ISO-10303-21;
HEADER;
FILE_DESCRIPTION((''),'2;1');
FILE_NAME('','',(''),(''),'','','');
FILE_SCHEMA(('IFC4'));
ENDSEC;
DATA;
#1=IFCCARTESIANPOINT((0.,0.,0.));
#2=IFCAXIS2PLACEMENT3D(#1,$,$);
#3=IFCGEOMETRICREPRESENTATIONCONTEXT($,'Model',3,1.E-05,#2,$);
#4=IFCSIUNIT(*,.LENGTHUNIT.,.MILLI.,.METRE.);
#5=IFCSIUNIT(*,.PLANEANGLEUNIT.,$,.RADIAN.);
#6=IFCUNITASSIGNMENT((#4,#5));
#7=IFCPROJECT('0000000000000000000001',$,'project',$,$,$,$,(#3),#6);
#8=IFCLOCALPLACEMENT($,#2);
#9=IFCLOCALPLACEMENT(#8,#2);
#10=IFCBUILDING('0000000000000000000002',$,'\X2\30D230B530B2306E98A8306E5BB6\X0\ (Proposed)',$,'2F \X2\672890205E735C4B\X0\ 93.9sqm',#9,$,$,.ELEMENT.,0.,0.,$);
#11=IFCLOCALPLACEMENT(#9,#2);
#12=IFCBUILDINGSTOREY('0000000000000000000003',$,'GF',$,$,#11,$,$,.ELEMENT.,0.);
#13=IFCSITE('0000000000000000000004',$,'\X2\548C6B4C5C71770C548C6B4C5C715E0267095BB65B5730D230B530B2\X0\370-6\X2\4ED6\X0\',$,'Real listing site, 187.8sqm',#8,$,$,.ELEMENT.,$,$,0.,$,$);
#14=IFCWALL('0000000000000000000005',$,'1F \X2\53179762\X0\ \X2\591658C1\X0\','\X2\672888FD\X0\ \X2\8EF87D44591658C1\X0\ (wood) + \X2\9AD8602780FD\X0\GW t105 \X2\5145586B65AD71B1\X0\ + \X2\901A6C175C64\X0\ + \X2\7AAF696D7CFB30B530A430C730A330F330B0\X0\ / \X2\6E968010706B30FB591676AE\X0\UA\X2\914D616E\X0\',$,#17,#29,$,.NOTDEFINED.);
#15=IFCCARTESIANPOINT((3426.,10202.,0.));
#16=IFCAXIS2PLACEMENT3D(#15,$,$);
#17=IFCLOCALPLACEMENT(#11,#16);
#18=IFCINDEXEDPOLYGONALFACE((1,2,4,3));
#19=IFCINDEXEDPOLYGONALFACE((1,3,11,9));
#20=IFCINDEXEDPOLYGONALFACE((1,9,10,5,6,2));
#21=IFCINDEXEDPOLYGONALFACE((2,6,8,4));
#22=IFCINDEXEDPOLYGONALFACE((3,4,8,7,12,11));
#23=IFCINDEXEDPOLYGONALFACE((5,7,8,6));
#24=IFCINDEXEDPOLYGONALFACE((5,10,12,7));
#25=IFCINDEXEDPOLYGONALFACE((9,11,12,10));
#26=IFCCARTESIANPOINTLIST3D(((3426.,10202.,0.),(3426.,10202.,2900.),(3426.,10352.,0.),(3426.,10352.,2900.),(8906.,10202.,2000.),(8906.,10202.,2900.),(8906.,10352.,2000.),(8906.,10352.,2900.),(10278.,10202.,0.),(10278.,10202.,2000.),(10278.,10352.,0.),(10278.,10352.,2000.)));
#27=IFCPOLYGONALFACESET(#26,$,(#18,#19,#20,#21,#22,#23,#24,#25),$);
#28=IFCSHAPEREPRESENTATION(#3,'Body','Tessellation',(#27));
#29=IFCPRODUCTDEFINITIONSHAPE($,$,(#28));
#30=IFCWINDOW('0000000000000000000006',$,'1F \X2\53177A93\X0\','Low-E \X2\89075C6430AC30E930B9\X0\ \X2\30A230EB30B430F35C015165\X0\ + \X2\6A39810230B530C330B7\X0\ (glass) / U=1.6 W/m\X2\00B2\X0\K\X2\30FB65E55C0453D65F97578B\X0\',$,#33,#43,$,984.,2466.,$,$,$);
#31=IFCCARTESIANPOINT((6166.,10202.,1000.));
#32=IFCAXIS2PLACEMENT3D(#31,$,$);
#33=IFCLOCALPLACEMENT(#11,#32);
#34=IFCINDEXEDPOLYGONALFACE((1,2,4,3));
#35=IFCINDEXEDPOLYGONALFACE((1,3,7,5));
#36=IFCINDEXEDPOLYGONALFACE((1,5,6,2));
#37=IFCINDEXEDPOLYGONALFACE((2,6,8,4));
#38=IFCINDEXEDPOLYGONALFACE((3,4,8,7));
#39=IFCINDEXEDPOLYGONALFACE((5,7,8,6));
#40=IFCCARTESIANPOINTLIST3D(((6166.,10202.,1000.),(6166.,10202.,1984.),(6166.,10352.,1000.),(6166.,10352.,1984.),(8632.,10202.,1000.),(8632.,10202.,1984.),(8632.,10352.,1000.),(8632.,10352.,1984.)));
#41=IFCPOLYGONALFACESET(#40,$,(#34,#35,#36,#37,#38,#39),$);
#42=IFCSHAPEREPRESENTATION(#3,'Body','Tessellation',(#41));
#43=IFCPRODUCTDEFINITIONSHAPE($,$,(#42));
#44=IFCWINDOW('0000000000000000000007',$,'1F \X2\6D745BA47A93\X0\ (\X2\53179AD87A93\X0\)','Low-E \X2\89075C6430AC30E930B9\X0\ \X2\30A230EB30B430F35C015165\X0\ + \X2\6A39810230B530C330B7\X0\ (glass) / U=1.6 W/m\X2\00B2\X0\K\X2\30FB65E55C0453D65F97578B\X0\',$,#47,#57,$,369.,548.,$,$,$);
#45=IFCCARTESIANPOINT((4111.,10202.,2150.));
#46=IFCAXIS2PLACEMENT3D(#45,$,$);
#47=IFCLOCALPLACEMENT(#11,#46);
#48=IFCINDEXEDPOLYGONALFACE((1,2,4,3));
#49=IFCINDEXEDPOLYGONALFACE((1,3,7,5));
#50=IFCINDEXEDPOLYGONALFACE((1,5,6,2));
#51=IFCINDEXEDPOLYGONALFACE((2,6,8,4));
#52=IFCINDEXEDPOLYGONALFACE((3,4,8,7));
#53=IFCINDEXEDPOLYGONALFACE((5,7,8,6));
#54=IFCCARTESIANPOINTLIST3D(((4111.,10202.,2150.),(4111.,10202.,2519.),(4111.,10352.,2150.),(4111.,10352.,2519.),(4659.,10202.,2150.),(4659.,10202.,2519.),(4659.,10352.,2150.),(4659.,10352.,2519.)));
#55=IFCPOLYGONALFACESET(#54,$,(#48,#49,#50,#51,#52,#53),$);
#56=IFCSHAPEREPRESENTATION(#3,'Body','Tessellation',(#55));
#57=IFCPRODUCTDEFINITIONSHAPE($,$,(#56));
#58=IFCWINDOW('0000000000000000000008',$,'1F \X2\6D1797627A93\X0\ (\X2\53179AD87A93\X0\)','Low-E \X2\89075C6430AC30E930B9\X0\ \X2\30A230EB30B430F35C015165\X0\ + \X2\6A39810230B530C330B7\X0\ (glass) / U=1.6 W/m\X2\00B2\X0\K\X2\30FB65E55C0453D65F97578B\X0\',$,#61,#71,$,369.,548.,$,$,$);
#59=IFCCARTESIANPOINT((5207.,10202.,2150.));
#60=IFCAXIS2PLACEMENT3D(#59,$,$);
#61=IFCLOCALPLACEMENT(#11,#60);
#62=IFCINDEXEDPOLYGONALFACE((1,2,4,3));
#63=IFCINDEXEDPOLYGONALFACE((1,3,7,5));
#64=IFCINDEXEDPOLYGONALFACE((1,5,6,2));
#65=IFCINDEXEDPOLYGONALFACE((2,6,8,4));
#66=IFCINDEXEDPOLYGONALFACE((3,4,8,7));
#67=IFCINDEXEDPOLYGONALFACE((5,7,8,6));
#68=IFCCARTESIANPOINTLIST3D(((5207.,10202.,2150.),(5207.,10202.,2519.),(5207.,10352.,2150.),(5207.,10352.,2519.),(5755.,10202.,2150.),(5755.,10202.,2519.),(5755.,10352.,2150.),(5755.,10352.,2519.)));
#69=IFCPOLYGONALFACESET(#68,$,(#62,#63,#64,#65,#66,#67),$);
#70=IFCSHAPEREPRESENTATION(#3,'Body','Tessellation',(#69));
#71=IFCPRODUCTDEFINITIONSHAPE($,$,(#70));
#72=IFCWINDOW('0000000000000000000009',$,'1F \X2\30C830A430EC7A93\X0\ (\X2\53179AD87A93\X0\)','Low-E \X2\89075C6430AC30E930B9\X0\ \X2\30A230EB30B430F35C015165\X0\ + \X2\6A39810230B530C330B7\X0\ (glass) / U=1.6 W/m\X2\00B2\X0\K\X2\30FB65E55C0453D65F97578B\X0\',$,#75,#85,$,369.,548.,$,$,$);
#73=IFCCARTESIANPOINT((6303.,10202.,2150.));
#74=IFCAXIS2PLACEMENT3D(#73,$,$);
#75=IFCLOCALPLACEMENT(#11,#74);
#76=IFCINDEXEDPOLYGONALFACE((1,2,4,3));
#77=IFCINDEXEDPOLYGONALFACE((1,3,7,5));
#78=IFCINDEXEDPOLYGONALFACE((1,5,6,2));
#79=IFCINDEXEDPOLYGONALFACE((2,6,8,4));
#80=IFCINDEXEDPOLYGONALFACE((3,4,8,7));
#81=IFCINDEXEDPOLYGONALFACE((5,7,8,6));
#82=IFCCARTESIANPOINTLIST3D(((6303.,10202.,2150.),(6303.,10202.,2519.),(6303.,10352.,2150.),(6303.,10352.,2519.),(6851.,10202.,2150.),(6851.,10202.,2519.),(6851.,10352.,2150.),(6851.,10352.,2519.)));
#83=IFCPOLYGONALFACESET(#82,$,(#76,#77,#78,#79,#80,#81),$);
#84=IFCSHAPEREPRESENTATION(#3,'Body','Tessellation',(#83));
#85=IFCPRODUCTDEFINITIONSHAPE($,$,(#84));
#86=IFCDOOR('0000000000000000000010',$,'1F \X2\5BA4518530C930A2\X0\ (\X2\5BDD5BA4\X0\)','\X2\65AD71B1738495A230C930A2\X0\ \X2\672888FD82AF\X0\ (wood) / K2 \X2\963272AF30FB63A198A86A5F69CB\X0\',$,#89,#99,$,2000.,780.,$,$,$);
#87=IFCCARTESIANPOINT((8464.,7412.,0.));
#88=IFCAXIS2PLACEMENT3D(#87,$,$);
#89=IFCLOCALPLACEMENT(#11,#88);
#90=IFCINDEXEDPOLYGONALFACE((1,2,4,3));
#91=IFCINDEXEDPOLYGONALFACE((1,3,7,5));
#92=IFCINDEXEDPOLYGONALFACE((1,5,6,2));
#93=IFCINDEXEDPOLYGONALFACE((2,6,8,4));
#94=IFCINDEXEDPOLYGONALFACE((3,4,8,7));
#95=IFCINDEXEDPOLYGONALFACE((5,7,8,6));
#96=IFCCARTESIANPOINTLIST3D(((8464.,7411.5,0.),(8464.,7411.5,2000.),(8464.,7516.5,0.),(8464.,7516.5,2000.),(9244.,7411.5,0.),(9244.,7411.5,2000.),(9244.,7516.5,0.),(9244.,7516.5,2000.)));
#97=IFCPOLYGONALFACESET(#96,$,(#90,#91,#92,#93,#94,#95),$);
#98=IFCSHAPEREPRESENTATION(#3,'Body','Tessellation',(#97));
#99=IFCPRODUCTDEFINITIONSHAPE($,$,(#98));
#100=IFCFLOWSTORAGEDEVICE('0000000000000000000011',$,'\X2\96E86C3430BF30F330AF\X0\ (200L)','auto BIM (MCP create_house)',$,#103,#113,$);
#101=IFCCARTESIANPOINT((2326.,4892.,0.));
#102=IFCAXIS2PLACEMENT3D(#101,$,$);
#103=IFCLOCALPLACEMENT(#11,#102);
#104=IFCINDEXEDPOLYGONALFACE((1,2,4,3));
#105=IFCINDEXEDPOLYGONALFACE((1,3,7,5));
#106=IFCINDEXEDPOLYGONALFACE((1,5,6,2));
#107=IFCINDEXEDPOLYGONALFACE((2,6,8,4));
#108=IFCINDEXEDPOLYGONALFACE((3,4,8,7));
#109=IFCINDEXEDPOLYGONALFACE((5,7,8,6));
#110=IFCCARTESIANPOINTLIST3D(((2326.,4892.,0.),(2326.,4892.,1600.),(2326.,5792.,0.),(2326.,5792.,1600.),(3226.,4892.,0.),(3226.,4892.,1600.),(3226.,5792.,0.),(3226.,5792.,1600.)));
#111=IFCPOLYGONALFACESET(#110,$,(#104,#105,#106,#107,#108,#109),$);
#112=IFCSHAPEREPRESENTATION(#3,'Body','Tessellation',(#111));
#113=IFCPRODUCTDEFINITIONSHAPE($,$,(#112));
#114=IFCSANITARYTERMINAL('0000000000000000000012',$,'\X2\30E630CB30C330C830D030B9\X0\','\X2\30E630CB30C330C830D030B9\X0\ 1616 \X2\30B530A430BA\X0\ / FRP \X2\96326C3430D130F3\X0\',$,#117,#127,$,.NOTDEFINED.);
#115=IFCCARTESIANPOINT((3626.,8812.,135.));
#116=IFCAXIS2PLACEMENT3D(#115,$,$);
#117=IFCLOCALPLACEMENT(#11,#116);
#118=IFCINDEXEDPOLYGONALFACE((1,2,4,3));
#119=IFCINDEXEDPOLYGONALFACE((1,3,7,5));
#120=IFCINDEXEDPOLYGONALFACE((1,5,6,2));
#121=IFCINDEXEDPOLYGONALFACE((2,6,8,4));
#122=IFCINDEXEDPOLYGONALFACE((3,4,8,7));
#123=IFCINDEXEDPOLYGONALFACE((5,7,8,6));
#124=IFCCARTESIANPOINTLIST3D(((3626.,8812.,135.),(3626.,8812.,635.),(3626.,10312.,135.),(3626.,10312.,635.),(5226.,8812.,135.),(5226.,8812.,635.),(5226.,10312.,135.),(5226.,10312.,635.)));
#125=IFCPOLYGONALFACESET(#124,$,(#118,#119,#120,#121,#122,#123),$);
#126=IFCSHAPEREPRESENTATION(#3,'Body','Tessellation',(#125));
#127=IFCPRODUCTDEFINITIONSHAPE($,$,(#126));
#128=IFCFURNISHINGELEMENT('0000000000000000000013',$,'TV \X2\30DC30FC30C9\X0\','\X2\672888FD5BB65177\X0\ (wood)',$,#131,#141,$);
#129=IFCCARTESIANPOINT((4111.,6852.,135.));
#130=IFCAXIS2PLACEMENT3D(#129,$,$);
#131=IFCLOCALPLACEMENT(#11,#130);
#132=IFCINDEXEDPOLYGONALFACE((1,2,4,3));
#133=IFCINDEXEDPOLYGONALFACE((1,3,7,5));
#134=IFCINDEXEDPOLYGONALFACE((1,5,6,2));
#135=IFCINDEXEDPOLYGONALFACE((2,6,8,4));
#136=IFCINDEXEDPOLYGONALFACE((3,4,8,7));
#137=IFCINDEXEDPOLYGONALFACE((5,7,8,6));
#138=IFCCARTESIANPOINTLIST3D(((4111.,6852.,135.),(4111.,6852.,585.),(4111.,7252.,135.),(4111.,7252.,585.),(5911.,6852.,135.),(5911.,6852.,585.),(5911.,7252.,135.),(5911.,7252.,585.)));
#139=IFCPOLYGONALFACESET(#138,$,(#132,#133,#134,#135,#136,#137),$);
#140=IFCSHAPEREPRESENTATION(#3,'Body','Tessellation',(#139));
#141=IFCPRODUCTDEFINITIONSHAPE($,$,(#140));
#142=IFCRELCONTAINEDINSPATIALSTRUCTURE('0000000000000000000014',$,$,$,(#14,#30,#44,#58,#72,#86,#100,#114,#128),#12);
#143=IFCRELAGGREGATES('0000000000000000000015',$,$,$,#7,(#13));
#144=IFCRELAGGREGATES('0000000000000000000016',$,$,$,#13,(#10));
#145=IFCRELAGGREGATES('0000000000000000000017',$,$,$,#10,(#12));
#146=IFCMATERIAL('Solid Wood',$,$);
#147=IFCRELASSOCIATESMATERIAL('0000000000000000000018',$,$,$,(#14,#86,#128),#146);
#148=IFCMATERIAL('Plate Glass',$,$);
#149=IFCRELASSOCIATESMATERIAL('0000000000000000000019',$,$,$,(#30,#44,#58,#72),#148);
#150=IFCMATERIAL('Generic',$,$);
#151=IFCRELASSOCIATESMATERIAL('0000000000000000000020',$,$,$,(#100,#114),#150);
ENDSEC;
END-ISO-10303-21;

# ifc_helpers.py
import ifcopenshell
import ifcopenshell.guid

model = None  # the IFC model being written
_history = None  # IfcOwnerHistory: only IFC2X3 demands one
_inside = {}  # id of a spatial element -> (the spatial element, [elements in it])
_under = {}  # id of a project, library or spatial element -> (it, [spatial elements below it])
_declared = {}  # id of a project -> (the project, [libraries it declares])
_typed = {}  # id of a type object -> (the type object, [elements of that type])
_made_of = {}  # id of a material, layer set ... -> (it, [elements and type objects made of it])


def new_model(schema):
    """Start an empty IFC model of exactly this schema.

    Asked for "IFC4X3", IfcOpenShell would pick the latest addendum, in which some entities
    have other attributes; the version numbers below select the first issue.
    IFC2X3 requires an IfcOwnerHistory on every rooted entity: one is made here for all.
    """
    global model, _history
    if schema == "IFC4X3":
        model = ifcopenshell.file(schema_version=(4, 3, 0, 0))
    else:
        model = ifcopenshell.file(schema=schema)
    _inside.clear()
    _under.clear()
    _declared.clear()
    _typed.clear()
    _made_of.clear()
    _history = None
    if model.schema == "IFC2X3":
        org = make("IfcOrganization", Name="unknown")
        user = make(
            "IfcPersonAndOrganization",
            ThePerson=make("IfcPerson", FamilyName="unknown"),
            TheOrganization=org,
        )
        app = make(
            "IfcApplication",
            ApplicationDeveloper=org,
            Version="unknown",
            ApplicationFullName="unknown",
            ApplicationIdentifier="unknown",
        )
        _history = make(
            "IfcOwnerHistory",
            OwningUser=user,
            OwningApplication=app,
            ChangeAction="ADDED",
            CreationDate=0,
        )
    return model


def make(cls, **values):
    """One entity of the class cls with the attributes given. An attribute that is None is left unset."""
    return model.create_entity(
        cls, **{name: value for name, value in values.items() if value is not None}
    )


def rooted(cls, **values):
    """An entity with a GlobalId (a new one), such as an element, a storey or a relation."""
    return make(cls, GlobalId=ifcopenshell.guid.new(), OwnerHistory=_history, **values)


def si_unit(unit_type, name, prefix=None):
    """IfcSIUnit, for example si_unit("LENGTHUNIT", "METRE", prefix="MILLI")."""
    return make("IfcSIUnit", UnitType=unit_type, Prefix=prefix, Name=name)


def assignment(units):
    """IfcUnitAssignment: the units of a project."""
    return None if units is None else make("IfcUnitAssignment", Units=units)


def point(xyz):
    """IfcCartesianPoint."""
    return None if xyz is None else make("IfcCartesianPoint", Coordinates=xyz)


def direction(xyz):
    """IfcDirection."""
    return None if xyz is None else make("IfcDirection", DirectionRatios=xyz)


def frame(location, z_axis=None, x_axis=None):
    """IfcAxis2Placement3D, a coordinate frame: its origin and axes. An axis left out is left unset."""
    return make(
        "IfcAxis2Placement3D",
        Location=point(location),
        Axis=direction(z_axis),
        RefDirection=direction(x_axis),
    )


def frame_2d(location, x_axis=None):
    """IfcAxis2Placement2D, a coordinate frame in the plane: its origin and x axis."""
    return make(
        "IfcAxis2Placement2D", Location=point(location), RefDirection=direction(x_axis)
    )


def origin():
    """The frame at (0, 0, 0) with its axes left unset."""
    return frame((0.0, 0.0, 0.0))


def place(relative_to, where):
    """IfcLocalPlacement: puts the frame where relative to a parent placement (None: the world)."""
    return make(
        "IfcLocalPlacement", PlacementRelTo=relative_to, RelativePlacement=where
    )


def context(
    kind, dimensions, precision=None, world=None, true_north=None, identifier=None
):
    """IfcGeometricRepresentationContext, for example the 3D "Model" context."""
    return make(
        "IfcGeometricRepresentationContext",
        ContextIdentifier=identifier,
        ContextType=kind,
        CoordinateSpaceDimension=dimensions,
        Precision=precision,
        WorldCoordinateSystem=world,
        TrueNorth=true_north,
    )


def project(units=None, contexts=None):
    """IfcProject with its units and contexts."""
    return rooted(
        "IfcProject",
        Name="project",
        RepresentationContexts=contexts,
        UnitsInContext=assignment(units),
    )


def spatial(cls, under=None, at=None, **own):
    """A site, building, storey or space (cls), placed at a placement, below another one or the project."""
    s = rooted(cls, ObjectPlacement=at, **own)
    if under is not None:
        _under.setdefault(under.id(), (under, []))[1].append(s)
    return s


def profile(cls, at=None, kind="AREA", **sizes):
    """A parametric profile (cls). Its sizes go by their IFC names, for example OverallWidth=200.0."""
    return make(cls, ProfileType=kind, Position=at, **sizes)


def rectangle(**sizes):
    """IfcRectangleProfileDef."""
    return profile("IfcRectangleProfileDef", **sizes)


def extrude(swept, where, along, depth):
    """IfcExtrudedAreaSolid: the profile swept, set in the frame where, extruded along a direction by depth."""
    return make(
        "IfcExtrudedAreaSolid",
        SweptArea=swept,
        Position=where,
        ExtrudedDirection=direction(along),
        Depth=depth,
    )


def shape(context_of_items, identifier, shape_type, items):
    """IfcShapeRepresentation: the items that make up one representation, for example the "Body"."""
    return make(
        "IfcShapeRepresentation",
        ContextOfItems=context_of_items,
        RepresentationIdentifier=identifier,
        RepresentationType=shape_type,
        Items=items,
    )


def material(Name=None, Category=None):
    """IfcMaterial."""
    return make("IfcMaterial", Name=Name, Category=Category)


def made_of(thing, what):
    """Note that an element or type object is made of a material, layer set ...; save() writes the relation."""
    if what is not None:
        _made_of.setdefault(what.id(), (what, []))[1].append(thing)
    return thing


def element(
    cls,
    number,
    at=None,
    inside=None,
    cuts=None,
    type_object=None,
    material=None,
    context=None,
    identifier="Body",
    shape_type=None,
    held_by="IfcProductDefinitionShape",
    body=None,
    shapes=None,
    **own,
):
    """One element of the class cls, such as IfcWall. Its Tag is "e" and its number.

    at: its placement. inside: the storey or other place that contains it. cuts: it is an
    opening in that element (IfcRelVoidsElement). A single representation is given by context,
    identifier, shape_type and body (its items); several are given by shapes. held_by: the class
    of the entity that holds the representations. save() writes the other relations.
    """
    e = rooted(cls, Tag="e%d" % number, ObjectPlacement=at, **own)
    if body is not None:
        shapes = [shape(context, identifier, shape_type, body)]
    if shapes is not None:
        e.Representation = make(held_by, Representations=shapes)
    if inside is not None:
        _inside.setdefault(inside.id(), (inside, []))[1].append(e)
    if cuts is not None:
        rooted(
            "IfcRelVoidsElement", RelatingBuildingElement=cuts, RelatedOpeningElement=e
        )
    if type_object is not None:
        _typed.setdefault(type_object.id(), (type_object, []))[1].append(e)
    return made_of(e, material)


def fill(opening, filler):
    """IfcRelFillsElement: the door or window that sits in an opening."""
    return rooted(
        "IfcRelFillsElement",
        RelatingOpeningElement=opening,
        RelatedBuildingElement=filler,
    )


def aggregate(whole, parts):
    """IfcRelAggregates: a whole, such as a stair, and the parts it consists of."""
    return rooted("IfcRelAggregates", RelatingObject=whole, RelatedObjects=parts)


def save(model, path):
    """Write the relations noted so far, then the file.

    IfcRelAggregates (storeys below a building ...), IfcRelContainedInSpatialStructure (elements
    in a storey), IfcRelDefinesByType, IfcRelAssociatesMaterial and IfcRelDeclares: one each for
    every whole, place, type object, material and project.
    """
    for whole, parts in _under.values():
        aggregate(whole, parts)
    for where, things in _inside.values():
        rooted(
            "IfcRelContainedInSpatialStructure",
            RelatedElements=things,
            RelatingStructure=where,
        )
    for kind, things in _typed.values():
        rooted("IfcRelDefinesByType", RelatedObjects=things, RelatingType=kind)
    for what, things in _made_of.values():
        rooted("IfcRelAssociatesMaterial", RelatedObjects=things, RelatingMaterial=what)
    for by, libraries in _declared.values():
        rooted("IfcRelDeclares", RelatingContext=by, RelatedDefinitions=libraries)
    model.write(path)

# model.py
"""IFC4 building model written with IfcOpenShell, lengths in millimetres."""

from ifc_helpers import new_model, si_unit, frame, frame_2d, origin, place, context, project, spatial, rectangle, extrude, material, element, fill, save


model = new_model("IFC4")

# Units and contexts
model_context = context("Model", 3, precision=1e-05, world=origin())
ifc_project = project(units=[si_unit("LENGTHUNIT", "METRE", prefix="MILLI"), si_unit("PLANEANGLEUNIT", "RADIAN")], contexts=[model_context])

# Site, building, storey
site_placement = place(None, origin())
site = spatial("IfcSite", under=ifc_project, at=site_placement, Name="和歌山県和歌山市有家字ヒサゲ370-6他", ObjectType="Real listing site, 187.8sqm", CompositionType="ELEMENT", RefElevation=0.0)
building_placement = place(site_placement, origin())
building = spatial("IfcBuilding", under=site, at=building_placement, Name="ヒサゲの風の家 (Proposed)", ObjectType="2F 木造平屋 93.9sqm", CompositionType="ELEMENT", ElevationOfRefHeight=0.0, ElevationOfTerrain=0.0)
storey_placement = place(building_placement, origin())
storey = spatial("IfcBuildingStorey", under=building, at=storey_placement, Name="GF", CompositionType="ELEMENT", Elevation=0.0)

# Wall, openings, windows
ifc_material_1 = material(Name="Solid Wood")
wall_1_placement = place(storey_placement, frame((3426.0, 10202.0, 0.0)))
wall_1 = element("IfcWall", 1, at=wall_1_placement, inside=storey, material=ifc_material_1, Name="1F 北面 外壁", Description="木製 軸組外壁 (wood) + 高性能GW t105 充填断熱 + 通気層 + 窯業系サイディング / 準耐火・外皮UA配慮", PredefinedType="NOTDEFINED", context=model_context, shape_type="SweptSolid", body=[
    extrude(rectangle(XDim=6852.0, YDim=150.0, at=frame_2d((3426.0, 75.0))), frame((3426.0, 10202.0, 0.0)), (0.0, 0.0, 1.0), 2900.0),
])
opening_1_placement = place(storey_placement, frame((6166.0, 10202.0, 1000.0)))
opening_1 = element("IfcOpeningElement", 2, at=opening_1_placement, cuts=wall_1, PredefinedType="NOTDEFINED", context=model_context, shape_type="SweptSolid", body=[
    extrude(rectangle(XDim=2466.0, YDim=150.0, at=frame_2d((1233.0, 75.0))), frame((6166.0, 10202.0, 1000.0)), (0.0, 0.0, 1.0), 984.0),
])
opening_2_placement = place(storey_placement, frame((4111.0, 10202.0, 2150.0)))
opening_2 = element("IfcOpeningElement", 3, at=opening_2_placement, cuts=wall_1, PredefinedType="NOTDEFINED", context=model_context, shape_type="SweptSolid", body=[
    extrude(rectangle(XDim=548.0, YDim=150.0, at=frame_2d((274.0, 75.0))), frame((4111.0, 10202.0, 2150.0)), (0.0, 0.0, 1.0), 369.0),
])
opening_3_placement = place(storey_placement, frame((5207.0, 10202.0, 2150.0)))
opening_3 = element("IfcOpeningElement", 4, at=opening_3_placement, cuts=wall_1, PredefinedType="NOTDEFINED", context=model_context, shape_type="SweptSolid", body=[
    extrude(rectangle(XDim=548.0, YDim=150.0, at=frame_2d((274.0, 75.0))), frame((5207.0, 10202.0, 2150.0)), (0.0, 0.0, 1.0), 369.0),
])
opening_4_placement = place(storey_placement, frame((6303.0, 10202.0, 2150.0)))
opening_4 = element("IfcOpeningElement", 5, at=opening_4_placement, cuts=wall_1, PredefinedType="NOTDEFINED", context=model_context, shape_type="SweptSolid", body=[
    extrude(rectangle(XDim=548.0, YDim=150.0, at=frame_2d((274.0, 75.0))), frame((6303.0, 10202.0, 2150.0)), (0.0, 0.0, 1.0), 369.0),
])
ifc_material_2 = material(Name="Plate Glass")
window_1_placement = place(storey_placement, frame((6166.0, 10202.0, 1000.0)))
window_1 = element("IfcWindow", 6, at=window_1_placement, inside=storey, material=ifc_material_2, Name="1F 北窓", Description="Low-E 複層ガラス アルゴン封入 + 樹脂サッシ (glass) / U=1.6 W/m²K・日射取得型", OverallHeight=984.0, OverallWidth=2466.0, context=model_context, shape_type="SweptSolid", body=[
    extrude(rectangle(XDim=2466.0, YDim=150.0, at=frame_2d((1233.0, 75.0))), frame((6166.0, 10202.0, 1000.0)), (0.0, 0.0, 1.0), 984.0),
])
fill(opening_1, window_1)
window_2_placement = place(storey_placement, frame((4111.0, 10202.0, 2150.0)))
window_2 = element("IfcWindow", 7, at=window_2_placement, inside=storey, material=ifc_material_2, Name="1F 浴室窓 (北高窓)", Description="Low-E 複層ガラス アルゴン封入 + 樹脂サッシ (glass) / U=1.6 W/m²K・日射取得型", OverallHeight=369.0, OverallWidth=548.0, context=model_context, shape_type="SweptSolid", body=[
    extrude(rectangle(XDim=548.0, YDim=150.0, at=frame_2d((274.0, 75.0))), frame((4111.0, 10202.0, 2150.0)), (0.0, 0.0, 1.0), 369.0),
])
fill(opening_2, window_2)
window_3_placement = place(storey_placement, frame((5207.0, 10202.0, 2150.0)))
window_3 = element("IfcWindow", 8, at=window_3_placement, inside=storey, material=ifc_material_2, Name="1F 洗面窓 (北高窓)", Description="Low-E 複層ガラス アルゴン封入 + 樹脂サッシ (glass) / U=1.6 W/m²K・日射取得型", OverallHeight=369.0, OverallWidth=548.0, context=model_context, shape_type="SweptSolid", body=[
    extrude(rectangle(XDim=548.0, YDim=150.0, at=frame_2d((274.0, 75.0))), frame((5207.0, 10202.0, 2150.0)), (0.0, 0.0, 1.0), 369.0),
])
fill(opening_3, window_3)
window_4_placement = place(storey_placement, frame((6303.0, 10202.0, 2150.0)))
window_4 = element("IfcWindow", 9, at=window_4_placement, inside=storey, material=ifc_material_2, Name="1F トイレ窓 (北高窓)", Description="Low-E 複層ガラス アルゴン封入 + 樹脂サッシ (glass) / U=1.6 W/m²K・日射取得型", OverallHeight=369.0, OverallWidth=548.0, context=model_context, shape_type="SweptSolid", body=[
    extrude(rectangle(XDim=548.0, YDim=150.0, at=frame_2d((274.0, 75.0))), frame((6303.0, 10202.0, 2150.0)), (0.0, 0.0, 1.0), 369.0),
])
fill(opening_4, window_4)

# Door
door_1_placement = place(storey_placement, frame((8464.0, 7412.0, 0.0)))
element("IfcDoor", 10, at=door_1_placement, inside=storey, material=ifc_material_1, Name="1F 室内ドア (寝室)", Description="断熱玄関ドア 木製芯 (wood) / K2 防犯・採風機構", OverallHeight=2000.0, OverallWidth=780.0, context=model_context, shape_type="SweptSolid", body=[
    extrude(rectangle(XDim=780.0, YDim=105.0, at=frame_2d((390.0, 52.0))), frame((8464.0, 7412.0, 0.0)), (0.0, 0.0, 1.0), 2000.0),
])

# Flow storage device
ifc_material_3 = material(Name="Generic")
flow_storage_device_placement = place(storey_placement, frame((2326.0, 4892.0, 0.0)))
element("IfcFlowStorageDevice", 11, at=flow_storage_device_placement, inside=storey, material=ifc_material_3, Name="雨水タンク (200L)", Description="auto BIM (MCP create_house)", context=model_context, shape_type="SweptSolid", body=[
    extrude(rectangle(XDim=900.0, YDim=900.0, at=frame_2d((450.0, 450.0))), frame((2326.0, 4892.0, 0.0)), (0.0, 0.0, 1.0), 1600.0),
])

# Sanitary terminal
sanitary_terminal_placement = place(storey_placement, frame((3626.0, 8812.0, 135.0)))
element("IfcSanitaryTerminal", 12, at=sanitary_terminal_placement, inside=storey, material=ifc_material_3, Name="ユニットバス", Description="ユニットバス 1616 サイズ / FRP 防水パン", PredefinedType="NOTDEFINED", context=model_context, shape_type="SweptSolid", body=[
    extrude(rectangle(XDim=1600.0, YDim=1500.0, at=frame_2d((800.0, 750.0))), frame((3626.0, 8812.0, 135.0)), (0.0, 0.0, 1.0), 500.0),
])

# Furnishing element
furnishing_placement = place(storey_placement, frame((4111.0, 6852.0, 135.0)))
element("IfcFurnishingElement", 13, at=furnishing_placement, inside=storey, material=ifc_material_1, Name="TV ボード", Description="木製家具 (wood)", context=model_context, shape_type="SweptSolid", body=[
    extrude(rectangle(XDim=1800.0, YDim=400.0, at=frame_2d((900.0, 200.0))), frame((4111.0, 6852.0, 135.0)), (0.0, 0.0, 1.0), 450.0),
])

save(model, "model.ifc")
